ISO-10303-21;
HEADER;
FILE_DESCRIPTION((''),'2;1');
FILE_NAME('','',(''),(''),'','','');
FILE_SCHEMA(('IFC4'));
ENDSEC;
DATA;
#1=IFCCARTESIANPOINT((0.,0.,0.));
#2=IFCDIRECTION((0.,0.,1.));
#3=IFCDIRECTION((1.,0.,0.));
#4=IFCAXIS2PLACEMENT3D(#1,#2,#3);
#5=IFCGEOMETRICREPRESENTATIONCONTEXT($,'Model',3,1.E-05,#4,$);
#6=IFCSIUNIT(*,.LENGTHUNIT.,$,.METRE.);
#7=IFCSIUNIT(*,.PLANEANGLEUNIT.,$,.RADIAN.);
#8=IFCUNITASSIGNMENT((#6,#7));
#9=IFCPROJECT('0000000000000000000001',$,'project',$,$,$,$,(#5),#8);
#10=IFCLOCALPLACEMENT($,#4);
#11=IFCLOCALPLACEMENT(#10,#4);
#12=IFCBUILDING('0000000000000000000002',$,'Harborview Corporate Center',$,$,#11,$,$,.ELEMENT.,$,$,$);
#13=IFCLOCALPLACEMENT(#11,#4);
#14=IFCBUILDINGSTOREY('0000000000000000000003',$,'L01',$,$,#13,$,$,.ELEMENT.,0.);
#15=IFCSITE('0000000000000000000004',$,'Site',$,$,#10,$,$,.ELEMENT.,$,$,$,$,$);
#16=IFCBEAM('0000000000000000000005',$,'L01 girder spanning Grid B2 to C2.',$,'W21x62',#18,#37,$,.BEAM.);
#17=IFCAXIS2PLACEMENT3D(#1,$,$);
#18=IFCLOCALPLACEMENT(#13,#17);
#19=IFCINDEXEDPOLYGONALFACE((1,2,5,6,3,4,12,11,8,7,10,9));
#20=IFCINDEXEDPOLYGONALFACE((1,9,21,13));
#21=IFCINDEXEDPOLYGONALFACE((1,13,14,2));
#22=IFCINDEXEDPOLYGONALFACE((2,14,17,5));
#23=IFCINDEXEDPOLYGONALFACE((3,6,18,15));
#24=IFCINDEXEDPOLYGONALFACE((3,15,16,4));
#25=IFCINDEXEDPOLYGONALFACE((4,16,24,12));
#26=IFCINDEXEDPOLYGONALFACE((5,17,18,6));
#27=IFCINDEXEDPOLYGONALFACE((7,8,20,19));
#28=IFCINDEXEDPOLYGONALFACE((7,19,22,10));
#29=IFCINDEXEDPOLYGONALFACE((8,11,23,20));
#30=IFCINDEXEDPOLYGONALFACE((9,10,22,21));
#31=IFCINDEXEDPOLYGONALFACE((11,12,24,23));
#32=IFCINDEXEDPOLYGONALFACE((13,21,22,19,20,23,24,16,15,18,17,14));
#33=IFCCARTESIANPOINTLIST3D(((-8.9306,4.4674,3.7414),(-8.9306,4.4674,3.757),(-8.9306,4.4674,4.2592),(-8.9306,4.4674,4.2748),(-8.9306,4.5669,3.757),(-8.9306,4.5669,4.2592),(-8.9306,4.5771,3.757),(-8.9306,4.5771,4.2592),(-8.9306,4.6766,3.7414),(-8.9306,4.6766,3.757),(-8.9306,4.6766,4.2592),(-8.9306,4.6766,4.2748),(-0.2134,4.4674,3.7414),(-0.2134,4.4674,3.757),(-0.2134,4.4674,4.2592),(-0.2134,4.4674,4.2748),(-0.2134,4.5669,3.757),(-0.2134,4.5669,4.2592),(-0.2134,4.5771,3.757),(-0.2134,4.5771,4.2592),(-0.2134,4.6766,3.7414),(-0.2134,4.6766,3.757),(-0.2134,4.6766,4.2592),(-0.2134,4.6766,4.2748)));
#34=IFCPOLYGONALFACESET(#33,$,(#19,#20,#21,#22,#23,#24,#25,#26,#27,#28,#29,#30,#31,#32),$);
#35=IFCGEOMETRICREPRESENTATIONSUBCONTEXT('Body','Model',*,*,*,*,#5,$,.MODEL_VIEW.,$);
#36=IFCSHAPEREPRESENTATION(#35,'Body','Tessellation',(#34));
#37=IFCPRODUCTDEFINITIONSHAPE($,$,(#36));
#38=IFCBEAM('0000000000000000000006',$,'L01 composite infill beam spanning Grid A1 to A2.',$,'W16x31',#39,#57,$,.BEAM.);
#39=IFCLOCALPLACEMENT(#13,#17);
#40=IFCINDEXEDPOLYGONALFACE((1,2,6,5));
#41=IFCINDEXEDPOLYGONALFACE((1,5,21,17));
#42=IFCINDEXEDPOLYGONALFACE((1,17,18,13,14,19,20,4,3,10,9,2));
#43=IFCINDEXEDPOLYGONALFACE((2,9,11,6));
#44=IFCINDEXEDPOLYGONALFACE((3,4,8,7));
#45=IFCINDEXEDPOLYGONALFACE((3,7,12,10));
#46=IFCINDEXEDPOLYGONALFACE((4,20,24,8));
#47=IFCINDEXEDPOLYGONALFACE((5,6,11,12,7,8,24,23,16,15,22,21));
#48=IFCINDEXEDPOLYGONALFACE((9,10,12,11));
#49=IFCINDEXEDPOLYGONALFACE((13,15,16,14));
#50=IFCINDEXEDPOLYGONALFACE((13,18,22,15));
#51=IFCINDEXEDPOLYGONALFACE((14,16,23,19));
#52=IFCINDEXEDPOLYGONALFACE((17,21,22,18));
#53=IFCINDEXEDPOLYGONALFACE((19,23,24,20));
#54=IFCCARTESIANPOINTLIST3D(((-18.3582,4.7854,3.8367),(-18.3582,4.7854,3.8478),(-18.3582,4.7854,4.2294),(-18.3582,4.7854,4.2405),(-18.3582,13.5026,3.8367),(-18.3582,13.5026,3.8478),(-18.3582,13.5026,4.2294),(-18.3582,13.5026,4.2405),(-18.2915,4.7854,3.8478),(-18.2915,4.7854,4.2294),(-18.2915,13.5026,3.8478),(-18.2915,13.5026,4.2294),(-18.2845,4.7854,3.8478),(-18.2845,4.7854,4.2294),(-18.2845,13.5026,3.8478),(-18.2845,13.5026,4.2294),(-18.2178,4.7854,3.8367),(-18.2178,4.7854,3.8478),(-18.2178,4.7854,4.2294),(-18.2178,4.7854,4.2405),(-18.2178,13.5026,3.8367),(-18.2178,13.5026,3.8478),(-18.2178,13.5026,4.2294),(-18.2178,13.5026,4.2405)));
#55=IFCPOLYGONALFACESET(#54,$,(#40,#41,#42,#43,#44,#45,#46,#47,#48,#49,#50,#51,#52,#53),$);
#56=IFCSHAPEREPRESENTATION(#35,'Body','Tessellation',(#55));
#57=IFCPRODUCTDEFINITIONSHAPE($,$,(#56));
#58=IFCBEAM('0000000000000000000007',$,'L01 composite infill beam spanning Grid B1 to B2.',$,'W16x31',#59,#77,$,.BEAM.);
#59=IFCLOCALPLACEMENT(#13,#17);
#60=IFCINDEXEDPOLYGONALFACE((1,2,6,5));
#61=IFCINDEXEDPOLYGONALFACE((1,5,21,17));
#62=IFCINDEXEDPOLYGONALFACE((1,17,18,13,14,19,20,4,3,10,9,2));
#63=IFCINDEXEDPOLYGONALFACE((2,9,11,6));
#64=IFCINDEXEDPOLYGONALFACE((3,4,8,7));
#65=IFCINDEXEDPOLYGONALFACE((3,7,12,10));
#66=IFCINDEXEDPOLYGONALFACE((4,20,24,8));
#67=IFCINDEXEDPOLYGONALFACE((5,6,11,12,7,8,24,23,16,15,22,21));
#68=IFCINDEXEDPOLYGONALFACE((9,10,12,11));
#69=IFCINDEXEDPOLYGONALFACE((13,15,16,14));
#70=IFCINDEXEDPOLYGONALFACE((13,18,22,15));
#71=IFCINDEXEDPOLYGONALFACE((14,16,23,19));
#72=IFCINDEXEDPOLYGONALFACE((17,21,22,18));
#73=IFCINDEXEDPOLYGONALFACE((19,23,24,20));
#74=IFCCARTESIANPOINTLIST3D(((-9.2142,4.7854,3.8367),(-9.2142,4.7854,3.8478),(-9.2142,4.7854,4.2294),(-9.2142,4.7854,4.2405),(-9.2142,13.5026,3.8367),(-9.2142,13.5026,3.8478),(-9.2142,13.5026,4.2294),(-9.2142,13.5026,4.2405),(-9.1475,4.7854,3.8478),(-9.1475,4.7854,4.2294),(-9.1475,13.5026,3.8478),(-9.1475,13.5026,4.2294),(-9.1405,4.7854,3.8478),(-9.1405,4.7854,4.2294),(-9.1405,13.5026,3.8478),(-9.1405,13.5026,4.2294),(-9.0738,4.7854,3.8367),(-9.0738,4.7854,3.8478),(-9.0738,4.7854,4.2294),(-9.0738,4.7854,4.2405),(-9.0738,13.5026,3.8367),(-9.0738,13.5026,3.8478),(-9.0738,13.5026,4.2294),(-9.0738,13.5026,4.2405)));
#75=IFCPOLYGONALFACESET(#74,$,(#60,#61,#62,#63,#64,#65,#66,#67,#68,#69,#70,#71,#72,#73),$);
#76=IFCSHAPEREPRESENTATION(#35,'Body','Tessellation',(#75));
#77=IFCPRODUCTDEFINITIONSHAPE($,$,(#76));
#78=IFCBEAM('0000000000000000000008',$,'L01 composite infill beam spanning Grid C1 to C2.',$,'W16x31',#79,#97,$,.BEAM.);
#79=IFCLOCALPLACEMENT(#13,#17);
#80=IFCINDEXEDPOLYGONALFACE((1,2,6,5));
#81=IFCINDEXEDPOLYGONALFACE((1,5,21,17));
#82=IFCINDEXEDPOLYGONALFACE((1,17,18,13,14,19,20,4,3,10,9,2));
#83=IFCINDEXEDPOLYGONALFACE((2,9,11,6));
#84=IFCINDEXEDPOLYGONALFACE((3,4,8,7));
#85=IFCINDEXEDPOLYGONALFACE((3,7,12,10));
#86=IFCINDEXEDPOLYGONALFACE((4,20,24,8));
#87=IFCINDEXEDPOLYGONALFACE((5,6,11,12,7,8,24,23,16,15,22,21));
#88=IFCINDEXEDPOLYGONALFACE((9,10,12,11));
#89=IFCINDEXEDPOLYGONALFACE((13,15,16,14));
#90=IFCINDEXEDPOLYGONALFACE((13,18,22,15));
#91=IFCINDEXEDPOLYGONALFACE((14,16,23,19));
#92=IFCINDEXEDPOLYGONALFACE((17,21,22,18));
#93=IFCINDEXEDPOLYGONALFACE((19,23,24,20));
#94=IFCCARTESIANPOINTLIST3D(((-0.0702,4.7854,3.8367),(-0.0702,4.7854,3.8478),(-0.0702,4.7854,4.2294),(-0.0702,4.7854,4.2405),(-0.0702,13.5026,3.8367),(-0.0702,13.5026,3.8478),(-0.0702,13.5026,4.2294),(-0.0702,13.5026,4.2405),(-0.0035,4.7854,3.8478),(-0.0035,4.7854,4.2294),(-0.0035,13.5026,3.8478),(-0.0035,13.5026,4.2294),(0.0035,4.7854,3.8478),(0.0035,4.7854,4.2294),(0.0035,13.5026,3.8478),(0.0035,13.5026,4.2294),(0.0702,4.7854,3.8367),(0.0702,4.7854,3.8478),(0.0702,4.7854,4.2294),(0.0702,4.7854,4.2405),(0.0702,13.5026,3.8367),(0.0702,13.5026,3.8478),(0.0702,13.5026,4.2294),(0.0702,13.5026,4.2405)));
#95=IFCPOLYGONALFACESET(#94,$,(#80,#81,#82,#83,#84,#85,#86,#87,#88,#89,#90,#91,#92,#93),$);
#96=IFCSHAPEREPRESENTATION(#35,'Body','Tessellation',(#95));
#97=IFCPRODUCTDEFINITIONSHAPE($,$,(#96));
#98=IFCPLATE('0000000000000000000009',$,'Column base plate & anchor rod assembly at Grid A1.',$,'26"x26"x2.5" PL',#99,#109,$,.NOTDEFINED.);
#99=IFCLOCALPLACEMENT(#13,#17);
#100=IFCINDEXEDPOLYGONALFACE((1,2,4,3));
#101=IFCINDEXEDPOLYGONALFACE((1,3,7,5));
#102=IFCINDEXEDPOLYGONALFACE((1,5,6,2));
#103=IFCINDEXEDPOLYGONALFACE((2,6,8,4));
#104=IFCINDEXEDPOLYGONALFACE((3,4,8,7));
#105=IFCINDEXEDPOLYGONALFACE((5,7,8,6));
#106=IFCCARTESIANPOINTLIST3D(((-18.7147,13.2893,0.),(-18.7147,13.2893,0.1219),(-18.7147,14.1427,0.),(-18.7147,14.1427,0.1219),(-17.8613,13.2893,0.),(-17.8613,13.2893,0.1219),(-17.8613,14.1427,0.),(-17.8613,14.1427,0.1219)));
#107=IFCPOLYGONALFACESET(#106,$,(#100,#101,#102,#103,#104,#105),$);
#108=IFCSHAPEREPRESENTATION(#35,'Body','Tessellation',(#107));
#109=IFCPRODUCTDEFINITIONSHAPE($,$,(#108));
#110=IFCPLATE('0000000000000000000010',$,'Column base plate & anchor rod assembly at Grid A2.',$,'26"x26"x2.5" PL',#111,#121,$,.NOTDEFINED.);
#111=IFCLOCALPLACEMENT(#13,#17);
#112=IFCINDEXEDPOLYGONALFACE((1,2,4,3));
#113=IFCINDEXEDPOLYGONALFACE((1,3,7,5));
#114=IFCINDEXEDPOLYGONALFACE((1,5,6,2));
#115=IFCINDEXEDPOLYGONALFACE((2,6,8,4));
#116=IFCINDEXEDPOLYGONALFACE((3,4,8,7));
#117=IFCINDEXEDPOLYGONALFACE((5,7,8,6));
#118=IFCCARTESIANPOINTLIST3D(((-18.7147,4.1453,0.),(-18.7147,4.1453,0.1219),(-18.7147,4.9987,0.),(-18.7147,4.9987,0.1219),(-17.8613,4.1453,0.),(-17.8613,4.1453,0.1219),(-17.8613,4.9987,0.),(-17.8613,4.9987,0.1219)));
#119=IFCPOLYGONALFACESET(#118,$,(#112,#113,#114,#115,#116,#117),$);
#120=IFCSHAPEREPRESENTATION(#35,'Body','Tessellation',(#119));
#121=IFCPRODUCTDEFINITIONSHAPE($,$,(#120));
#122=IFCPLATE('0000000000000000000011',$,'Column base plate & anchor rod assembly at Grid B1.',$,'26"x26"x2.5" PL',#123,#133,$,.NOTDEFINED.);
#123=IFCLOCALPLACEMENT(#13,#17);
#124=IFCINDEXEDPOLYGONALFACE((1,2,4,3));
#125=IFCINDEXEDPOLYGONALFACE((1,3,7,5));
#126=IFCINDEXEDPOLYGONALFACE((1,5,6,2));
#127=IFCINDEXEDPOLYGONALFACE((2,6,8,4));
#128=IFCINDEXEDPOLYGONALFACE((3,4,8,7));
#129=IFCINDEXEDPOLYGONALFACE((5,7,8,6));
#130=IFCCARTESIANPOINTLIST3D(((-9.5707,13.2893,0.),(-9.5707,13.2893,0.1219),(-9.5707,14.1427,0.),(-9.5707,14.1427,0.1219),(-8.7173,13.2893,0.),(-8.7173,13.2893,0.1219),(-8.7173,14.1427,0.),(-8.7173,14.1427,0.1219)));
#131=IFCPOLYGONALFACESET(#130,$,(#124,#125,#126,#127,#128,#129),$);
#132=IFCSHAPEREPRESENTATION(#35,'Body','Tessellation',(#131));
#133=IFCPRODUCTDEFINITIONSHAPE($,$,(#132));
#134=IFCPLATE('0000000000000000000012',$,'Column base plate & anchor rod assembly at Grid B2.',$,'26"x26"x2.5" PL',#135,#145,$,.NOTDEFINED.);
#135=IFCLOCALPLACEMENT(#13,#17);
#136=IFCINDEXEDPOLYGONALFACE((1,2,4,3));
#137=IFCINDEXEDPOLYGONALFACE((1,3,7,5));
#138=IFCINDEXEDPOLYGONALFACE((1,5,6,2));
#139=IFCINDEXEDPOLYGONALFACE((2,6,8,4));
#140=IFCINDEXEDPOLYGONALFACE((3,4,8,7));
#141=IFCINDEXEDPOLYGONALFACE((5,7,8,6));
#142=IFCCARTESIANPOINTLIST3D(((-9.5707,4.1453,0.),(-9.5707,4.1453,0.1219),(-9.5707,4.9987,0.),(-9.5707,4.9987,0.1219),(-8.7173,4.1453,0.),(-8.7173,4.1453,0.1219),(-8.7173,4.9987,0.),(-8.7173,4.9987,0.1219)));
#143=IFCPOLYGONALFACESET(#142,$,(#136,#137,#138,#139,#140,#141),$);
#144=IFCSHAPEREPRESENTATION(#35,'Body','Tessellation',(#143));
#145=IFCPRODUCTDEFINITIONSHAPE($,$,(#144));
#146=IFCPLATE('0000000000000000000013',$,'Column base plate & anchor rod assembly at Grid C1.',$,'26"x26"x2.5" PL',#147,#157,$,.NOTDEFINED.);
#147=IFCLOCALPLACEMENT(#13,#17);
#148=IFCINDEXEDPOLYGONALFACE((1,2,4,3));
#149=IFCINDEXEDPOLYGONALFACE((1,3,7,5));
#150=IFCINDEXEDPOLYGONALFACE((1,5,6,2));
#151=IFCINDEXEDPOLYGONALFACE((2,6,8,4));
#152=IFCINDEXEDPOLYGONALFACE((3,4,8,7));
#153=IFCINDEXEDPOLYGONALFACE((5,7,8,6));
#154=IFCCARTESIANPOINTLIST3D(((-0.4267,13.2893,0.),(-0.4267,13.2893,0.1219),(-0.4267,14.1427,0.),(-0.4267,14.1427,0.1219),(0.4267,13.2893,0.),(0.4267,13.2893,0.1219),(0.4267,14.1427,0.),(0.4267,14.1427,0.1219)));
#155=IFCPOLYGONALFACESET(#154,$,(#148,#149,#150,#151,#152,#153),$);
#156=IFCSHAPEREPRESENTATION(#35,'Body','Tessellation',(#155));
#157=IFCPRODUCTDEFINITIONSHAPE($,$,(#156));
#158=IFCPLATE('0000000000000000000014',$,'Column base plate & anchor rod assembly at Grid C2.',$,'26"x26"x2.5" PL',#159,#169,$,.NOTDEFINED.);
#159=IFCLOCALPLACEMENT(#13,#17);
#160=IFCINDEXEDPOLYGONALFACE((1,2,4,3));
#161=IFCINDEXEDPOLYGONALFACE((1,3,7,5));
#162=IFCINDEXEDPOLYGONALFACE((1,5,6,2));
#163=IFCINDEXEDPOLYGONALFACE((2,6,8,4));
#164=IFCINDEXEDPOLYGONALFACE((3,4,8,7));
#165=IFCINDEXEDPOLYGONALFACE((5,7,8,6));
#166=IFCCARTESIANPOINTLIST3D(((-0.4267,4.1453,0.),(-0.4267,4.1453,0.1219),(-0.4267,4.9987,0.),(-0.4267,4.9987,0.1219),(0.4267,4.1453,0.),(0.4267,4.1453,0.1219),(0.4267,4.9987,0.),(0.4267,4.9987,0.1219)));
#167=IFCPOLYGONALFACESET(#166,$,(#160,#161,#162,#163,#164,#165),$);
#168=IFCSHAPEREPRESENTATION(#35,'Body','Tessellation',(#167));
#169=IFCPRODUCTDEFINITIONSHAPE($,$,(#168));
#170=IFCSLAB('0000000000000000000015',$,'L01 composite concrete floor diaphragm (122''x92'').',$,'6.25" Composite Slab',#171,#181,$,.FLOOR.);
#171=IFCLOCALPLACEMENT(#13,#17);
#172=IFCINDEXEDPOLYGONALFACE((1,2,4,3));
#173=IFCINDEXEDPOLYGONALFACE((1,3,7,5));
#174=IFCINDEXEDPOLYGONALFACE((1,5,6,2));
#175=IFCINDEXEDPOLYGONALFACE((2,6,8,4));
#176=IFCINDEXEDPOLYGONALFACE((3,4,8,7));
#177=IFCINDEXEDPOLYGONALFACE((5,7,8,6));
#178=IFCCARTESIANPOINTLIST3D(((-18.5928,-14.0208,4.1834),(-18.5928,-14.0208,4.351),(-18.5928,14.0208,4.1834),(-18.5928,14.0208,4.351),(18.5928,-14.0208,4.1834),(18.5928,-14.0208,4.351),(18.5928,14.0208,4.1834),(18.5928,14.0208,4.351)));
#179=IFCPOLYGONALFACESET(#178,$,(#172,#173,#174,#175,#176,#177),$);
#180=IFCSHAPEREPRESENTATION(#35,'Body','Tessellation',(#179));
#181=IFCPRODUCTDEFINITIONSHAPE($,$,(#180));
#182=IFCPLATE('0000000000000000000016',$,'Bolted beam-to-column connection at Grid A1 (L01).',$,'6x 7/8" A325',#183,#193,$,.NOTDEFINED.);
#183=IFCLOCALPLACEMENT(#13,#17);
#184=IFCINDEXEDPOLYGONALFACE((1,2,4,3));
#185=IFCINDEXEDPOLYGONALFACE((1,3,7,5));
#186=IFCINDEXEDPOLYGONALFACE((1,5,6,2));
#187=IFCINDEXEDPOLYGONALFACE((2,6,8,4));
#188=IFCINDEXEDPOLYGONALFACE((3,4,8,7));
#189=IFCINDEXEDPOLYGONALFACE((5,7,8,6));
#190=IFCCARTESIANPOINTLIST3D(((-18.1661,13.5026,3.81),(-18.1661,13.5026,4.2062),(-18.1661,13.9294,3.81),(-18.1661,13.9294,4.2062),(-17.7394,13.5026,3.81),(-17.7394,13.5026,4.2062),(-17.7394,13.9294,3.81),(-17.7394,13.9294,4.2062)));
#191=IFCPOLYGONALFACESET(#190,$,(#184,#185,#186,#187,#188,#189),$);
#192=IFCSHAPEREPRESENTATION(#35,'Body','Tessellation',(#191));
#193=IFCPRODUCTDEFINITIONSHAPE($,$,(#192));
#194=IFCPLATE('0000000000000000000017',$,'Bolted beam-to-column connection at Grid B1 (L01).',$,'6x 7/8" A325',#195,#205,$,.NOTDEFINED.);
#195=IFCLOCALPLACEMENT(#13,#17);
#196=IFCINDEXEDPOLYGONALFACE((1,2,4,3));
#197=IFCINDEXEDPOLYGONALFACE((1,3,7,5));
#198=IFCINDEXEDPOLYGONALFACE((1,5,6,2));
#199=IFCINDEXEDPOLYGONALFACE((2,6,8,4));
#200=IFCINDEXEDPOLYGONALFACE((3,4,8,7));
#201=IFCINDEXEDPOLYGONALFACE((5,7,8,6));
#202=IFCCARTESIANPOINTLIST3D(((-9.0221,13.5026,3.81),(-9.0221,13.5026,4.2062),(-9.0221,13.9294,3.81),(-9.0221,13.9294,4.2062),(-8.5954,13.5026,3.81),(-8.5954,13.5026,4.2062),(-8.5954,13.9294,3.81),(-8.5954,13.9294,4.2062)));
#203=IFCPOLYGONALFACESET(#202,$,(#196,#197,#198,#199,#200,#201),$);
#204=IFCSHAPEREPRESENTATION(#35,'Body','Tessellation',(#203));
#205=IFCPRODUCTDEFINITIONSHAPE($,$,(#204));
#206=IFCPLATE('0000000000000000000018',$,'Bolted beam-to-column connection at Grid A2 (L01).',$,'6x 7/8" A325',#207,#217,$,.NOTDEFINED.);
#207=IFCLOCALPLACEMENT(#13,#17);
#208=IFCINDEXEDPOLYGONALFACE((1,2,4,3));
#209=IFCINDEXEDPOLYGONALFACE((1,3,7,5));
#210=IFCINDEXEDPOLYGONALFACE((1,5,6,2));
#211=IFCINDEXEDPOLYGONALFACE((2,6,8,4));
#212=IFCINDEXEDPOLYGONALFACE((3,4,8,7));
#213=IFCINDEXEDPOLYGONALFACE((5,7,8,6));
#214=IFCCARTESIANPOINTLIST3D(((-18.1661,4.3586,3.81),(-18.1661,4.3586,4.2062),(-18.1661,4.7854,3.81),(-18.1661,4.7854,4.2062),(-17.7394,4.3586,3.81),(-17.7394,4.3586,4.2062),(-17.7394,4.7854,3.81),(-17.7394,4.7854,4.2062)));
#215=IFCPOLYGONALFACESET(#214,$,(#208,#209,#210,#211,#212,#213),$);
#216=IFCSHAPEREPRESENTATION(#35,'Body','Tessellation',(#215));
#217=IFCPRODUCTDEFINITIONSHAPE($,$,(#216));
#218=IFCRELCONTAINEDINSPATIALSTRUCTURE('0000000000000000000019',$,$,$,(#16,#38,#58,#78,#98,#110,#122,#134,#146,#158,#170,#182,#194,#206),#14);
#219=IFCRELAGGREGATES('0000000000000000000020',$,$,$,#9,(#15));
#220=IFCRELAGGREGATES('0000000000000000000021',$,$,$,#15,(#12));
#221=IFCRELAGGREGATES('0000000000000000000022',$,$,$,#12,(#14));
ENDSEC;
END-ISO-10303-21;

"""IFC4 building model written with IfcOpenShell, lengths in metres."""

from ifc_helpers import new_model, si_unit, frame, origin_with_axes, place, context, subcontext, project, spatial, rectangle, i_section, extrude, element, save


model = new_model("IFC4")

# Units and contexts
model_context = context("Model", 3, precision=1e-05, world=origin_with_axes())
body_context = subcontext(model_context, "Body", "Model", "MODEL_VIEW")
ifc_project = project(units=[si_unit("LENGTHUNIT", "METRE"), si_unit("PLANEANGLEUNIT", "RADIAN")], contexts=[model_context])

# Site, building, storey
site_placement = place(None, origin_with_axes())
site = spatial("IfcSite", under=ifc_project, at=site_placement, Name="Site", CompositionType="ELEMENT")
building_placement = place(site_placement, origin_with_axes())
building = spatial("IfcBuilding", under=site, at=building_placement, Name="Harborview Corporate Center", CompositionType="ELEMENT")
storey_placement = place(building_placement, origin_with_axes())
storey = spatial("IfcBuildingStorey", under=building, at=storey_placement, Name="L01", CompositionType="ELEMENT", Elevation=0.0)

# Beams
beam_1_placement = place(storey_placement, frame((-8.9306, 4.572, 4.0081), z_axis=(1.0, 0.0, 0.0), x_axis=(0.0, 1.0, 0.0)))
element("IfcBeam", 1, at=beam_1_placement, inside=storey, Name="L01 girder spanning Grid B2 to C2.", ObjectType="W21x62", PredefinedType="BEAM", context=body_context, shape_type="SweptSolid", body=[
    extrude(i_section(OverallWidth=0.2093, OverallDepth=0.5334, WebThickness=0.0102, FlangeThickness=0.0156), origin_with_axes(), (0.0, 0.0, 1.0), 8.7173),
])
for number, where, z_axis, x_axis, name in (
    (2, (-18.288, 4.7854, 4.0386), (0.0, 1.0, 0.0), (-1.0, 0.0, 0.0), "L01 composite infill beam spanning Grid A1 to A2."),
    (3, (-9.144, 4.7854, 4.0386), (0.0, 1.0, 0.0), (-1.0, 0.0, 0.0), "L01 composite infill beam spanning Grid B1 to B2."),
    (4, (0.0, 4.7854, 4.0386), (0.0, 1.0, 0.0), (-1.0, 0.0, 0.0), "L01 composite infill beam spanning Grid C1 to C2."),
):
    element("IfcBeam", number, at=place(storey_placement, frame(where, z_axis=z_axis, x_axis=x_axis)), inside=storey, Name=name, ObjectType="W16x31", PredefinedType="BEAM", context=body_context, shape_type="SweptSolid", body=[
        extrude(i_section(OverallWidth=0.1405, OverallDepth=0.4039, WebThickness=0.007, FlangeThickness=0.0112), origin_with_axes(), (0.0, 0.0, 1.0), 8.7173),
    ])

# Plates
plate_1_placement = place(storey_placement, frame((-18.288, 13.716, 0.0), z_axis=(0.0, 0.0, 1.0), x_axis=(1.0, 0.0, 0.0)))
element("IfcPlate", 5, at=plate_1_placement, inside=storey, Name="Column base plate & anchor rod assembly at Grid A1.", ObjectType="26\"x26\"x2.5\" PL", PredefinedType="NOTDEFINED", context=body_context, shape_type="SweptSolid", body=[
    extrude(rectangle(XDim=0.8534, YDim=0.8534), origin_with_axes(), (0.0, 0.0, 1.0), 0.1219),
])
plate_2_placement = place(storey_placement, frame((-18.288, 4.572, 0.0), z_axis=(0.0, 0.0, 1.0), x_axis=(1.0, 0.0, 0.0)))
element("IfcPlate", 6, at=plate_2_placement, inside=storey, Name="Column base plate & anchor rod assembly at Grid A2.", ObjectType="26\"x26\"x2.5\" PL", PredefinedType="NOTDEFINED", context=body_context, shape_type="SweptSolid", body=[
    extrude(rectangle(XDim=0.8534, YDim=0.8534), origin_with_axes(), (0.0, 0.0, 1.0), 0.1219),
])
plate_3_placement = place(storey_placement, frame((-9.144, 13.716, 0.0), z_axis=(0.0, 0.0, 1.0), x_axis=(1.0, 0.0, 0.0)))
element("IfcPlate", 7, at=plate_3_placement, inside=storey, Name="Column base plate & anchor rod assembly at Grid B1.", ObjectType="26\"x26\"x2.5\" PL", PredefinedType="NOTDEFINED", context=body_context, shape_type="SweptSolid", body=[
    extrude(rectangle(XDim=0.8534, YDim=0.8534), origin_with_axes(), (0.0, 0.0, 1.0), 0.1219),
])
plate_4_placement = place(storey_placement, frame((-9.144, 4.572, 0.0), z_axis=(0.0, 0.0, 1.0), x_axis=(1.0, 0.0, 0.0)))
element("IfcPlate", 8, at=plate_4_placement, inside=storey, Name="Column base plate & anchor rod assembly at Grid B2.", ObjectType="26\"x26\"x2.5\" PL", PredefinedType="NOTDEFINED", context=body_context, shape_type="SweptSolid", body=[
    extrude(rectangle(XDim=0.8534, YDim=0.8534), origin_with_axes(), (0.0, 0.0, 1.0), 0.1219),
])
plate_5_placement = place(storey_placement, frame((0.0, 13.716, 0.0), z_axis=(0.0, 0.0, 1.0), x_axis=(1.0, 0.0, 0.0)))
element("IfcPlate", 9, at=plate_5_placement, inside=storey, Name="Column base plate & anchor rod assembly at Grid C1.", ObjectType="26\"x26\"x2.5\" PL", PredefinedType="NOTDEFINED", context=body_context, shape_type="SweptSolid", body=[
    extrude(rectangle(XDim=0.8534, YDim=0.8534), origin_with_axes(), (0.0, 0.0, 1.0), 0.1219),
])
plate_6_placement = place(storey_placement, frame((0.0, 4.572, 0.0), z_axis=(0.0, 0.0, 1.0), x_axis=(1.0, 0.0, 0.0)))
element("IfcPlate", 10, at=plate_6_placement, inside=storey, Name="Column base plate & anchor rod assembly at Grid C2.", ObjectType="26\"x26\"x2.5\" PL", PredefinedType="NOTDEFINED", context=body_context, shape_type="SweptSolid", body=[
    extrude(rectangle(XDim=0.8534, YDim=0.8534), origin_with_axes(), (0.0, 0.0, 1.0), 0.1219),
])

# Slab
slab_placement = place(storey_placement, frame((0.0, 0.0, 4.1834), z_axis=(0.0, 0.0, 1.0), x_axis=(1.0, 0.0, 0.0)))
element("IfcSlab", 11, at=slab_placement, inside=storey, Name="L01 composite concrete floor diaphragm (122'x92').", ObjectType="6.25\" Composite Slab", PredefinedType="FLOOR", context=body_context, shape_type="SweptSolid", body=[
    extrude(rectangle(XDim=37.1856, YDim=28.0416), origin_with_axes(), (0.0, 0.0, 1.0), 0.1676),
])

# Plates
plate_7_placement = place(storey_placement, frame((-17.9527, 13.716, 3.81), z_axis=(0.0, 0.0, 1.0), x_axis=(1.0, 0.0, 0.0)))
element("IfcPlate", 12, at=plate_7_placement, inside=storey, Name="Bolted beam-to-column connection at Grid A1 (L01).", ObjectType="6x 7/8\" A325", PredefinedType="NOTDEFINED", context=body_context, shape_type="SweptSolid", body=[
    extrude(rectangle(XDim=0.4267, YDim=0.4267), origin_with_axes(), (0.0, 0.0, 1.0), 0.3962),
])
plate_8_placement = place(storey_placement, frame((-8.8087, 13.716, 3.81), z_axis=(0.0, 0.0, 1.0), x_axis=(1.0, 0.0, 0.0)))
element("IfcPlate", 13, at=plate_8_placement, inside=storey, Name="Bolted beam-to-column connection at Grid B1 (L01).", ObjectType="6x 7/8\" A325", PredefinedType="NOTDEFINED", context=body_context, shape_type="SweptSolid", body=[
    extrude(rectangle(XDim=0.4267, YDim=0.4267), origin_with_axes(), (0.0, 0.0, 1.0), 0.3962),
])
plate_9_placement = place(storey_placement, frame((-17.9527, 4.572, 3.81), z_axis=(0.0, 0.0, 1.0), x_axis=(1.0, 0.0, 0.0)))
element("IfcPlate", 14, at=plate_9_placement, inside=storey, Name="Bolted beam-to-column connection at Grid A2 (L01).", ObjectType="6x 7/8\" A325", PredefinedType="NOTDEFINED", context=body_context, shape_type="SweptSolid", body=[
    extrude(rectangle(XDim=0.4267, YDim=0.4267), origin_with_axes(), (0.0, 0.0, 1.0), 0.3962),
])

save(model, "model.ifc")
